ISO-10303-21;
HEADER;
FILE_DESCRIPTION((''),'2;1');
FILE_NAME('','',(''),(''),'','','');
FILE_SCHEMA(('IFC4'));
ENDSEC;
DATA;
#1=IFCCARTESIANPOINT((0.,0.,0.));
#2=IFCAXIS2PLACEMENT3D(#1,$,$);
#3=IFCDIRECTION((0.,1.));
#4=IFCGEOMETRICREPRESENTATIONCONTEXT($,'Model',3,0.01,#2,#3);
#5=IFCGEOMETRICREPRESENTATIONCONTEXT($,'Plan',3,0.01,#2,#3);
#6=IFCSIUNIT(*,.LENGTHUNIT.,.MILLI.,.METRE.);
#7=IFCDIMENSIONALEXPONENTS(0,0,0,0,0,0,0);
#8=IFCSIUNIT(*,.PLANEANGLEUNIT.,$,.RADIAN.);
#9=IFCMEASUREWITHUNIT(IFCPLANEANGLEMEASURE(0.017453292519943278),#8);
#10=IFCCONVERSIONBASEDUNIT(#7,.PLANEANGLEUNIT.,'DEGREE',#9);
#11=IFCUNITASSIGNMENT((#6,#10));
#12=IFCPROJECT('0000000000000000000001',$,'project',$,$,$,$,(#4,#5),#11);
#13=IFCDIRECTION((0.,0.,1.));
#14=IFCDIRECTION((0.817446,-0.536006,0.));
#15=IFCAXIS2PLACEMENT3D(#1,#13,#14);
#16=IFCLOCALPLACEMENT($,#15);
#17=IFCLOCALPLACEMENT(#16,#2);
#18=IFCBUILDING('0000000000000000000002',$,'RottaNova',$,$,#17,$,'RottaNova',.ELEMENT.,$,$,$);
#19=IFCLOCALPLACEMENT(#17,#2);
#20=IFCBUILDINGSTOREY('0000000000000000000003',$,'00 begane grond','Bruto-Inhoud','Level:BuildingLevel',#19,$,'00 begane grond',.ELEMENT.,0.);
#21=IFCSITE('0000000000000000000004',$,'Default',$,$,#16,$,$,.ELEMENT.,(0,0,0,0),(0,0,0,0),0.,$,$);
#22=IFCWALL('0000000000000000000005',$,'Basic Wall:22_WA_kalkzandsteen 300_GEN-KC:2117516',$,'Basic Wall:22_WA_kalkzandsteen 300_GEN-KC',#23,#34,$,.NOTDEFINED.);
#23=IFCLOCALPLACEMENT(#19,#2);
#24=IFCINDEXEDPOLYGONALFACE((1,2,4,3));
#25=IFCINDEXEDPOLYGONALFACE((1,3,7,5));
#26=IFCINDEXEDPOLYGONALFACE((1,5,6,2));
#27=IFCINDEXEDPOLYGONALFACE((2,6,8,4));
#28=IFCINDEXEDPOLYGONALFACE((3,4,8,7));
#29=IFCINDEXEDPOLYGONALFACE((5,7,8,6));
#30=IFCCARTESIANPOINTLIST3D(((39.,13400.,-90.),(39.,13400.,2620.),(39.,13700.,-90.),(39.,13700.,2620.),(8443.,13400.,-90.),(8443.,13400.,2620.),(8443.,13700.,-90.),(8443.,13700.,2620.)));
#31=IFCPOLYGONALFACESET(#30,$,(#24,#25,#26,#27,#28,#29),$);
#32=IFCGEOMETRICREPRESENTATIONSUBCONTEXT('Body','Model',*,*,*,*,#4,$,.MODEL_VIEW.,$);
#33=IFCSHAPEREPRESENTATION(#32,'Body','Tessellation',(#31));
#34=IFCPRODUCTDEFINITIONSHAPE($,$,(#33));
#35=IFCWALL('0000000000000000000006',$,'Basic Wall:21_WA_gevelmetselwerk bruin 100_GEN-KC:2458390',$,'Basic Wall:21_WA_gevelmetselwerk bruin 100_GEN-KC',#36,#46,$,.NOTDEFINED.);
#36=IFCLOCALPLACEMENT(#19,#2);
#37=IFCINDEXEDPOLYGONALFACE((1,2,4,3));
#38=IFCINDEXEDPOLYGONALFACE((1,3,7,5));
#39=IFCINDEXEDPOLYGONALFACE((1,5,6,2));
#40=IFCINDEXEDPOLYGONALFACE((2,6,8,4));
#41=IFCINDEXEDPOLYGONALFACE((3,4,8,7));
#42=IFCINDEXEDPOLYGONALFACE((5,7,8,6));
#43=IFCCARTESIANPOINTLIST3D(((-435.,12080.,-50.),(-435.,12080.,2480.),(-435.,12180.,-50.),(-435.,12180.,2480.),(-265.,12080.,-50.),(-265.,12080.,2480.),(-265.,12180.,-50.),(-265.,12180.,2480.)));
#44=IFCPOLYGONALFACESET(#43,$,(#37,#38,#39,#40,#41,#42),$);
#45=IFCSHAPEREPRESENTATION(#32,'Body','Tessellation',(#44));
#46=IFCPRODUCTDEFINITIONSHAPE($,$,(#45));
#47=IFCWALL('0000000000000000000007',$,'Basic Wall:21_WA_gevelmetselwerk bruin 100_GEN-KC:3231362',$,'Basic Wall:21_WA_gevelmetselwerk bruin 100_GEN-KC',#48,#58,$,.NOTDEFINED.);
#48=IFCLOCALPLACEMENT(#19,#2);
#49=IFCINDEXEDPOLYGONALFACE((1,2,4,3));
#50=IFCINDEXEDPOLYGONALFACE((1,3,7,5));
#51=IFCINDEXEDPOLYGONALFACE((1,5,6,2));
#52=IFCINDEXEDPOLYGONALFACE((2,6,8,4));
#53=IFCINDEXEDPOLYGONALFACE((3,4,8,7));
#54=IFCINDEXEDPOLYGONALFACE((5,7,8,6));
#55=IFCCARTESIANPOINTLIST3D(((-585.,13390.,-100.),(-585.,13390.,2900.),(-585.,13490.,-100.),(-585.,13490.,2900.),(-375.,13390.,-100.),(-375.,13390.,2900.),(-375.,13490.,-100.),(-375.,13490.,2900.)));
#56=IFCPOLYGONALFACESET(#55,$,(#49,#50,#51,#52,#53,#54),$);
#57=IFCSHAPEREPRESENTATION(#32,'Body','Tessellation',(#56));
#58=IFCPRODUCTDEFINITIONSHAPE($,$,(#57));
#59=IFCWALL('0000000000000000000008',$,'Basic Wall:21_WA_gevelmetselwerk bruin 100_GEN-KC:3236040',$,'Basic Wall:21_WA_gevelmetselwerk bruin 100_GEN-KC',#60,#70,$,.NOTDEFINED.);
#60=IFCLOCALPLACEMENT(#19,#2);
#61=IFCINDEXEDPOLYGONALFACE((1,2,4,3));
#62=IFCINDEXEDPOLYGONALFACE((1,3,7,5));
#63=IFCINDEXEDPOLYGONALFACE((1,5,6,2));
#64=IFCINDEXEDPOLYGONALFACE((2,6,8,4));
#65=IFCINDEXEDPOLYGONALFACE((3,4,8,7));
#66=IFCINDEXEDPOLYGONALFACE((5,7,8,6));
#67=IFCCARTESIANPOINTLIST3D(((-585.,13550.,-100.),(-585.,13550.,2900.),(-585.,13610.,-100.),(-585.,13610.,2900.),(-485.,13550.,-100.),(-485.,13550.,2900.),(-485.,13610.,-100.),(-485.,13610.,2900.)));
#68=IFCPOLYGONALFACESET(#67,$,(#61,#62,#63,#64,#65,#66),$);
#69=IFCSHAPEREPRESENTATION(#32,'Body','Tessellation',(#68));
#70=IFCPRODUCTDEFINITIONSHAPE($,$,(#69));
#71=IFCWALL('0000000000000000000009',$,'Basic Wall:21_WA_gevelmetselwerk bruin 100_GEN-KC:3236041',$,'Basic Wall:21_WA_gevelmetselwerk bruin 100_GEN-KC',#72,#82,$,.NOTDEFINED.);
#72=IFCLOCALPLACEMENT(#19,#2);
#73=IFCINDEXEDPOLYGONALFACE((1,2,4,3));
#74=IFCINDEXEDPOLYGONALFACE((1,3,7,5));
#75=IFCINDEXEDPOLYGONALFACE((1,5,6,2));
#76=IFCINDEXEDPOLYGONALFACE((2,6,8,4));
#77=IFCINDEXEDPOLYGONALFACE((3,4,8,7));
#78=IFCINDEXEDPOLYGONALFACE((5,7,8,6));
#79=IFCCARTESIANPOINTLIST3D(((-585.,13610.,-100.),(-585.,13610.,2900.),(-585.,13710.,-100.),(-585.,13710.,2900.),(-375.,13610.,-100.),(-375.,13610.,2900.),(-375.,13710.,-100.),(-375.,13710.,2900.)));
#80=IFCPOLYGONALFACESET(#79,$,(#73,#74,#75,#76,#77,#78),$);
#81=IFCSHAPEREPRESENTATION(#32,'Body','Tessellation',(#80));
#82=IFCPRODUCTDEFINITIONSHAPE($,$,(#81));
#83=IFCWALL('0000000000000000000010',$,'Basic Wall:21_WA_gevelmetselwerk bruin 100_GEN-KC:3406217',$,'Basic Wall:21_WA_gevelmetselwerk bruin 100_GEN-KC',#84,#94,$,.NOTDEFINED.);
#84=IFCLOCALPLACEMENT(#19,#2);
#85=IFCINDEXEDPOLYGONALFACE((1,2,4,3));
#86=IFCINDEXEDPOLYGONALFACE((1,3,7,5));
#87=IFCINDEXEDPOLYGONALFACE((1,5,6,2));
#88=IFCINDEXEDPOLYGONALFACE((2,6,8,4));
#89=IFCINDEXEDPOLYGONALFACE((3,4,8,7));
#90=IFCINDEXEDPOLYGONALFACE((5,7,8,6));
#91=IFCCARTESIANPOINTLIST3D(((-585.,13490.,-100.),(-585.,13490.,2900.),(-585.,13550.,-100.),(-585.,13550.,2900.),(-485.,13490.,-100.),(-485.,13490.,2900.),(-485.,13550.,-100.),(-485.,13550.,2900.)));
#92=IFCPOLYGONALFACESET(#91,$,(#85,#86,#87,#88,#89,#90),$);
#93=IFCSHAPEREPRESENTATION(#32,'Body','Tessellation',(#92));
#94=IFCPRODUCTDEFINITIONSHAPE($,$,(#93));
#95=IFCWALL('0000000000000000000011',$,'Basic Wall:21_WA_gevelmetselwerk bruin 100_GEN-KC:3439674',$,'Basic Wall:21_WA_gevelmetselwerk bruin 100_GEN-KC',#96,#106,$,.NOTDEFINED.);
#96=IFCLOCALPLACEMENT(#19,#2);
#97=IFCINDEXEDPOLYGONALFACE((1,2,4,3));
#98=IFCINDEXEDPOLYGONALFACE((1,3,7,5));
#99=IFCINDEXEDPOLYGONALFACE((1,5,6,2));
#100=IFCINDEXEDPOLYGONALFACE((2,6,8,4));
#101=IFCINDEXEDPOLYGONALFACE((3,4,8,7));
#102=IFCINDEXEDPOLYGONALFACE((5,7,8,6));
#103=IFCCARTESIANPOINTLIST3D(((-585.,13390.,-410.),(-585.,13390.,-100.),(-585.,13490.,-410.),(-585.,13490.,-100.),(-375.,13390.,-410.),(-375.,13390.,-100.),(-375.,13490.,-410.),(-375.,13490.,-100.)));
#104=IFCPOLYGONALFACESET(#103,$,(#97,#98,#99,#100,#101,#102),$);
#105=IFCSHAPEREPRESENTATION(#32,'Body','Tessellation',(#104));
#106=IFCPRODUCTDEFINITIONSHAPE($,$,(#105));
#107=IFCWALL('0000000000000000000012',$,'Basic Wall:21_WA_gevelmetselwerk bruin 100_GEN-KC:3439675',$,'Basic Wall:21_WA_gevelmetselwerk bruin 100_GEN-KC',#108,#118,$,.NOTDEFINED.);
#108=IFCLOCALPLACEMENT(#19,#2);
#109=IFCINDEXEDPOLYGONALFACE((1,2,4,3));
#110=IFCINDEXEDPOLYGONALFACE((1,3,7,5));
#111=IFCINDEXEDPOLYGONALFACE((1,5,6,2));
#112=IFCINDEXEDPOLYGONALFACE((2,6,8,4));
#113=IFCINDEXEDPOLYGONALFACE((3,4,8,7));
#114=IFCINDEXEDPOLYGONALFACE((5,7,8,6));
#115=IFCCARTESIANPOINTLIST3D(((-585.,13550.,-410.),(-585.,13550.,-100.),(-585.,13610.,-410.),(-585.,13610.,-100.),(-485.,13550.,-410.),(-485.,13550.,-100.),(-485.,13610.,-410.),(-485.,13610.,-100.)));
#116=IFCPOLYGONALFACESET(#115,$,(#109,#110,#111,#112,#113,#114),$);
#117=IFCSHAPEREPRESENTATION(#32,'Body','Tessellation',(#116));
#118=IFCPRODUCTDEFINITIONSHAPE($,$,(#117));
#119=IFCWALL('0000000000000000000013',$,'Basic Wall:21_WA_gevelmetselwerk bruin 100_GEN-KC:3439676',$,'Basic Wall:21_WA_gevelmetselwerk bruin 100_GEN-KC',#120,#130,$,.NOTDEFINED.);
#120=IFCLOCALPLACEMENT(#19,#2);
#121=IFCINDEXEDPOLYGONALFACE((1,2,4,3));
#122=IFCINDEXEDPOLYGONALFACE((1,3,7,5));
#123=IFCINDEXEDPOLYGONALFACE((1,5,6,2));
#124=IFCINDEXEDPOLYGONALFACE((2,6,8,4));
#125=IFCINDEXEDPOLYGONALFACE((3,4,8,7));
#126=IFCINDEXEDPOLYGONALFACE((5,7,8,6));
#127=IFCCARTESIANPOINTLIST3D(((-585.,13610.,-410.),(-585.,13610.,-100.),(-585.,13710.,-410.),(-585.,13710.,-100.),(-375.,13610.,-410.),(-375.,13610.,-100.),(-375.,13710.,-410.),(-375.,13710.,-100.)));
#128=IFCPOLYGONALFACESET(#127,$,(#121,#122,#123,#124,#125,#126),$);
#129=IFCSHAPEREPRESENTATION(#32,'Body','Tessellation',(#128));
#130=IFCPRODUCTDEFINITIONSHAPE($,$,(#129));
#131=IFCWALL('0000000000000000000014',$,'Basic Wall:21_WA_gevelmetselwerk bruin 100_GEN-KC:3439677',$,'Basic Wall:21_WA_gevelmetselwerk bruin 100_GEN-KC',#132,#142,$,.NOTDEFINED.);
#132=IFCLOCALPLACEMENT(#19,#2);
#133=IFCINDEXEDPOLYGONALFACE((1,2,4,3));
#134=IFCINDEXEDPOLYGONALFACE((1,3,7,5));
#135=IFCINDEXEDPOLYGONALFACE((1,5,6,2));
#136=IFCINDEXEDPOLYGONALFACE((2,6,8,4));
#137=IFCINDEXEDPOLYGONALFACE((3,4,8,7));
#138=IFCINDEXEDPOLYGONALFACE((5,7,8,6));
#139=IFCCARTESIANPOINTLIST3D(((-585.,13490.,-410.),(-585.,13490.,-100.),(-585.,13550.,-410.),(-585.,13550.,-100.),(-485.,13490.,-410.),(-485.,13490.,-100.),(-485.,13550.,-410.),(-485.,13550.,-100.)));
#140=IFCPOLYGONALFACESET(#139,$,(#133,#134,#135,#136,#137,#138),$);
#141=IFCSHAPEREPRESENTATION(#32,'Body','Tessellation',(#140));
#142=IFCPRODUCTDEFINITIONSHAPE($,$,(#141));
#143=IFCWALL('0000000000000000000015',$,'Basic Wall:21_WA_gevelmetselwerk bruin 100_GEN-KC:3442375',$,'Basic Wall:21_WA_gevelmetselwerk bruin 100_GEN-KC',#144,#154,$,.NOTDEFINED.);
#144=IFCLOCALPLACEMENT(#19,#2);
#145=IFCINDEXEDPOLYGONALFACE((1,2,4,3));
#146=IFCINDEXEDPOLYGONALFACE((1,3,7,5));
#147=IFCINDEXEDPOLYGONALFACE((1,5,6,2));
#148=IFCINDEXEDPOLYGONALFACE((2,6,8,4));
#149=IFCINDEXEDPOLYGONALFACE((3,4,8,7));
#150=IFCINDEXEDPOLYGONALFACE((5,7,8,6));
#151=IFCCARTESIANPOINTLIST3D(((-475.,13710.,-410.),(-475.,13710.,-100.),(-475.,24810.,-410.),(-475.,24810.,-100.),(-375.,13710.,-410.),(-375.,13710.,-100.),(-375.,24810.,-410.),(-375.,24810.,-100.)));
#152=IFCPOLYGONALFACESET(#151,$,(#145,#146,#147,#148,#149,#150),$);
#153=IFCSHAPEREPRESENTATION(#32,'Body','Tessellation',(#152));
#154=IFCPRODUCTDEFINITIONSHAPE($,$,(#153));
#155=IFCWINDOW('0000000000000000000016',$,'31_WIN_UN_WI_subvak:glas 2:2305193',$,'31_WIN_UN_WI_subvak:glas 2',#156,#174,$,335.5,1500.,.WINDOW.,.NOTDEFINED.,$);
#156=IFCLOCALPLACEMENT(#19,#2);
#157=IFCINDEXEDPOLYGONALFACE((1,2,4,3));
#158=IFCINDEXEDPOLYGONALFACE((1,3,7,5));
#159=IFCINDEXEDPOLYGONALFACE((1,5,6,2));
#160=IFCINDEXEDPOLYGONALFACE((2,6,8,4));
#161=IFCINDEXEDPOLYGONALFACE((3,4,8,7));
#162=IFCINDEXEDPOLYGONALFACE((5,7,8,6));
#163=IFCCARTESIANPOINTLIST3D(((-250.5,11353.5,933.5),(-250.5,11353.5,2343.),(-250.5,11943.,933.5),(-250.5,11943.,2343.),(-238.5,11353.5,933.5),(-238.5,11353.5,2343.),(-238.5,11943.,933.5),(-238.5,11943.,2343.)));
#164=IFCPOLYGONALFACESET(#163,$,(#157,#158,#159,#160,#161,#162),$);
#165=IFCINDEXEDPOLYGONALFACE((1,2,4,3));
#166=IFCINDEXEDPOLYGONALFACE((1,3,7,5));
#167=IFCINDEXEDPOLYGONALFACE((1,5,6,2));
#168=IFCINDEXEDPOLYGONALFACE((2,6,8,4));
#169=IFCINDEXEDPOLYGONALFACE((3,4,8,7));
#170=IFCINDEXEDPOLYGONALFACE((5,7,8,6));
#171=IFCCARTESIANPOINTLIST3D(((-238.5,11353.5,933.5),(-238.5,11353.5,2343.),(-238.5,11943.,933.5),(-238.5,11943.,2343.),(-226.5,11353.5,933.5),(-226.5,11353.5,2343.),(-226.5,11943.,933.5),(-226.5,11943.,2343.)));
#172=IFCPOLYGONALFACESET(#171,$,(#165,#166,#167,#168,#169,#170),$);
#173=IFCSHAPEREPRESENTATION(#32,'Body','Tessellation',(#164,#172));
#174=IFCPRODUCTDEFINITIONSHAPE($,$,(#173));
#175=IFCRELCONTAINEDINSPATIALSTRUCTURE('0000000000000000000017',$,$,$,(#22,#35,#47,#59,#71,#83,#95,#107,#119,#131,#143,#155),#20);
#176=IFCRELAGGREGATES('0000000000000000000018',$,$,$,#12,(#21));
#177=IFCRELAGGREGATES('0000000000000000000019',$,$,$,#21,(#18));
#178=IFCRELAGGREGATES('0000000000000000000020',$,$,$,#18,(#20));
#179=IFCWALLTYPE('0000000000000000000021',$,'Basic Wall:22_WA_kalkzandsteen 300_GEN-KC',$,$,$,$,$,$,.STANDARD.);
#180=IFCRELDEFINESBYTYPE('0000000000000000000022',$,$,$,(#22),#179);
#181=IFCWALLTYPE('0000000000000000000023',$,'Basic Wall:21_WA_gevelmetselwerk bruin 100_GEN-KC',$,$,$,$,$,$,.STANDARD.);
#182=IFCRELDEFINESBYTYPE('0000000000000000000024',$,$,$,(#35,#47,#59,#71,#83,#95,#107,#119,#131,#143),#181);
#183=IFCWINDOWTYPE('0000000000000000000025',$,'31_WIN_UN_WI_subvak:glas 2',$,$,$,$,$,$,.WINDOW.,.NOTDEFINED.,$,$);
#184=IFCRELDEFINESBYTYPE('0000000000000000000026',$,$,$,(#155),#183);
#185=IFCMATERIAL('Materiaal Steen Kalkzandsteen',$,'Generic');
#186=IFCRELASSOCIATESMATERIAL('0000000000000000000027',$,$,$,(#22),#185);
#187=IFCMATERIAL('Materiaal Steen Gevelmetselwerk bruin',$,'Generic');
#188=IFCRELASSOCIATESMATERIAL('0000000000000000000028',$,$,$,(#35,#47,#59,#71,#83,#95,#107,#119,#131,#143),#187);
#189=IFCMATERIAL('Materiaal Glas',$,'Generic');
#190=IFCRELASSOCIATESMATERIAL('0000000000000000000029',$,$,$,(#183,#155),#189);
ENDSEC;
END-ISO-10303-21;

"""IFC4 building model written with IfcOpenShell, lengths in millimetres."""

from ifc_helpers import new_model, entity, si_unit, converted_unit, direction, frame, origin, place, context, subcontext, project, spatial, indexed_curve, outline, extrude, source, transform, mapped, material, type_object, type_shapes, element, save


model = new_model("IFC4")

# Units and contexts
model_context = context("Model", 3, precision=0.01, world=origin(), true_north=direction((0.0, 1.0)))
plan_context = context("Plan", 3, precision=0.01, world=origin(), true_north=direction((0.0, 1.0)))
body_context = subcontext(model_context, "Body", "Model", "MODEL_VIEW")
ifc_project = project(units=[si_unit("LENGTHUNIT", "METRE", prefix="MILLI"), converted_unit("PLANEANGLEUNIT", "DEGREE", entity("IfcPlaneAngleMeasure", 0.017453292519943278), si_unit("PLANEANGLEUNIT", "RADIAN"), dimensions=[0, 0, 0, 0, 0, 0, 0])], contexts=[model_context, plan_context])

# Site, building, storey
site_placement = place(None, frame((0.0, 0.0, 0.0), z_axis=(0.0, 0.0, 1.0), x_axis=(0.817446, -0.536006, 0.0)))
site = spatial("IfcSite", under=ifc_project, at=site_placement, Name="Default", CompositionType="ELEMENT", RefLatitude=(0, 0, 0, 0), RefLongitude=(0, 0, 0, 0), RefElevation=0.0)
building_placement = place(site_placement, origin())
building = spatial("IfcBuilding", under=site, at=building_placement, Name="RottaNova", LongName="RottaNova", CompositionType="ELEMENT")
storey_placement = place(building_placement, origin())
storey = spatial("IfcBuildingStorey", under=building, at=storey_placement, Name="00 begane grond", Description="Bruto-Inhoud", ObjectType="Level:BuildingLevel", LongName="00 begane grond", CompositionType="ELEMENT", Elevation=0.0)

# Shared definitions
ifc_material_1 = material(Name="Materiaal Glas", Category="Generic")

# Walls
ifc_material_2 = material(Name="Materiaal Steen Kalkzandsteen", Category="Generic")
wall_type_1 = type_object("IfcWallType", Name="Basic Wall:22_WA_kalkzandsteen 300_GEN-KC", PredefinedType="STANDARD")
wall_1_placement = place(storey_placement, frame((39.0, 13550.0, -90.0)))
element("IfcWall", 1, at=wall_1_placement, inside=storey, type_object=wall_type_1, material=ifc_material_2, Name="Basic Wall:22_WA_kalkzandsteen 300_GEN-KC:2117516", ObjectType="Basic Wall:22_WA_kalkzandsteen 300_GEN-KC", PredefinedType="NOTDEFINED", context=body_context, shape_type="SweptSolid", body=[
    extrude(outline(indexed_curve([(8404.0, 150.0), (0.0, 150.0), (0.0, -150.0), (8404.0, -150.0), (8404.0, 150.0)], self_intersect=False)), origin(), (0.0, 0.0, 1.0), 2710.0),
])
ifc_material_3 = material(Name="Materiaal Steen Gevelmetselwerk bruin", Category="Generic")
wall_type_2 = type_object("IfcWallType", Name="Basic Wall:21_WA_gevelmetselwerk bruin 100_GEN-KC", PredefinedType="STANDARD")
wall_2_placement = place(storey_placement, frame((-435.0, 12130.0, -50.0)))
element("IfcWall", 2, at=wall_2_placement, inside=storey, type_object=wall_type_2, material=ifc_material_3, Name="Basic Wall:21_WA_gevelmetselwerk bruin 100_GEN-KC:2458390", ObjectType="Basic Wall:21_WA_gevelmetselwerk bruin 100_GEN-KC", PredefinedType="NOTDEFINED", context=body_context, shape_type="SweptSolid", body=[
    extrude(outline(indexed_curve([(170.0, 50.0), (0.0, 50.0), (0.0, -50.0), (170.0, -50.0), (170.0, 50.0)], self_intersect=False)), origin(), (0.0, 0.0, 1.0), 2530.0),
])
wall_3_placement = place(storey_placement, frame((-585.0, 13440.0, -100.0)))
element("IfcWall", 3, at=wall_3_placement, inside=storey, type_object=wall_type_2, material=ifc_material_3, Name="Basic Wall:21_WA_gevelmetselwerk bruin 100_GEN-KC:3231362", ObjectType="Basic Wall:21_WA_gevelmetselwerk bruin 100_GEN-KC", PredefinedType="NOTDEFINED", context=body_context, shape_type="SweptSolid", body=[
    extrude(outline(indexed_curve([(210.0, 50.0), (0.0, 50.0), (0.0, -50.0), (210.0, -50.0), (210.0, 50.0)], self_intersect=False)), origin(), (0.0, 0.0, 1.0), 3000.0),
])
wall_4_placement = place(storey_placement, frame((-535.0, 13550.0, -100.0), z_axis=(0.0, 0.0, 1.0), x_axis=(0.0, 1.0, 0.0)))
element("IfcWall", 4, at=wall_4_placement, inside=storey, type_object=wall_type_2, material=ifc_material_3, Name="Basic Wall:21_WA_gevelmetselwerk bruin 100_GEN-KC:3236040", ObjectType="Basic Wall:21_WA_gevelmetselwerk bruin 100_GEN-KC", PredefinedType="NOTDEFINED", context=body_context, shape_type="SweptSolid", body=[
    extrude(outline(indexed_curve([(60.0, 50.0), (0.0, 50.0), (0.0, -50.0), (60.0, -50.0), (60.0, 50.0)], self_intersect=False)), origin(), (0.0, 0.0, 1.0), 3000.0),
])
wall_5_placement = place(storey_placement, frame((-585.0, 13660.0, -100.0)))
element("IfcWall", 5, at=wall_5_placement, inside=storey, type_object=wall_type_2, material=ifc_material_3, Name="Basic Wall:21_WA_gevelmetselwerk bruin 100_GEN-KC:3236041", ObjectType="Basic Wall:21_WA_gevelmetselwerk bruin 100_GEN-KC", PredefinedType="NOTDEFINED", context=body_context, shape_type="SweptSolid", body=[
    extrude(outline(indexed_curve([(210.0, 50.0), (0.0, 50.0), (0.0, -50.0), (210.0, -50.0), (210.0, 50.0)], self_intersect=False)), origin(), (0.0, 0.0, 1.0), 3000.0),
])
wall_6_placement = place(storey_placement, frame((-535.0, 13490.0, -100.0), z_axis=(0.0, 0.0, 1.0), x_axis=(0.0, 1.0, 0.0)))
element("IfcWall", 6, at=wall_6_placement, inside=storey, type_object=wall_type_2, material=ifc_material_3, Name="Basic Wall:21_WA_gevelmetselwerk bruin 100_GEN-KC:3406217", ObjectType="Basic Wall:21_WA_gevelmetselwerk bruin 100_GEN-KC", PredefinedType="NOTDEFINED", context=body_context, shape_type="SweptSolid", body=[
    extrude(outline(indexed_curve([(60.0, 50.0), (0.0, 50.0), (0.0, -50.0), (60.0, -50.0), (60.0, 50.0)], self_intersect=False)), origin(), (0.0, 0.0, 1.0), 3000.0),
])
wall_7_placement = place(storey_placement, frame((-585.0, 13440.0, -410.0)))
element("IfcWall", 7, at=wall_7_placement, inside=storey, type_object=wall_type_2, material=ifc_material_3, Name="Basic Wall:21_WA_gevelmetselwerk bruin 100_GEN-KC:3439674", ObjectType="Basic Wall:21_WA_gevelmetselwerk bruin 100_GEN-KC", PredefinedType="NOTDEFINED", context=body_context, shape_type="SweptSolid", body=[
    extrude(outline(indexed_curve([(210.0, 50.0), (0.0, 50.0), (0.0, -50.0), (210.0, -50.0), (210.0, 50.0)], self_intersect=False)), origin(), (0.0, 0.0, 1.0), 310.0),
])
wall_8_placement = place(storey_placement, frame((-535.0, 13550.0, -410.0), z_axis=(0.0, 0.0, 1.0), x_axis=(0.0, 1.0, 0.0)))
element("IfcWall", 8, at=wall_8_placement, inside=storey, type_object=wall_type_2, material=ifc_material_3, Name="Basic Wall:21_WA_gevelmetselwerk bruin 100_GEN-KC:3439675", ObjectType="Basic Wall:21_WA_gevelmetselwerk bruin 100_GEN-KC", PredefinedType="NOTDEFINED", context=body_context, shape_type="SweptSolid", body=[
    extrude(outline(indexed_curve([(60.0, 50.0), (0.0, 50.0), (0.0, -50.0), (60.0, -50.0), (60.0, 50.0)], self_intersect=False)), origin(), (0.0, 0.0, 1.0), 310.0),
])
wall_9_placement = place(storey_placement, frame((-585.0, 13660.0, -410.0)))
element("IfcWall", 9, at=wall_9_placement, inside=storey, type_object=wall_type_2, material=ifc_material_3, Name="Basic Wall:21_WA_gevelmetselwerk bruin 100_GEN-KC:3439676", ObjectType="Basic Wall:21_WA_gevelmetselwerk bruin 100_GEN-KC", PredefinedType="NOTDEFINED", context=body_context, shape_type="SweptSolid", body=[
    extrude(outline(indexed_curve([(210.0, 50.0), (0.0, 50.0), (0.0, -50.0), (210.0, -50.0), (210.0, 50.0)], self_intersect=False)), origin(), (0.0, 0.0, 1.0), 310.0),
])
wall_10_placement = place(storey_placement, frame((-535.0, 13490.0, -410.0), z_axis=(0.0, 0.0, 1.0), x_axis=(0.0, 1.0, 0.0)))
element("IfcWall", 10, at=wall_10_placement, inside=storey, type_object=wall_type_2, material=ifc_material_3, Name="Basic Wall:21_WA_gevelmetselwerk bruin 100_GEN-KC:3439677", ObjectType="Basic Wall:21_WA_gevelmetselwerk bruin 100_GEN-KC", PredefinedType="NOTDEFINED", context=body_context, shape_type="SweptSolid", body=[
    extrude(outline(indexed_curve([(60.0, 50.0), (0.0, 50.0), (0.0, -50.0), (60.0, -50.0), (60.0, 50.0)], self_intersect=False)), origin(), (0.0, 0.0, 1.0), 310.0),
])
wall_11_placement = place(storey_placement, frame((-425.0, 13710.0, -410.0), z_axis=(0.0, 0.0, 1.0), x_axis=(0.0, 1.0, 0.0)))
element("IfcWall", 11, at=wall_11_placement, inside=storey, type_object=wall_type_2, material=ifc_material_3, Name="Basic Wall:21_WA_gevelmetselwerk bruin 100_GEN-KC:3442375", ObjectType="Basic Wall:21_WA_gevelmetselwerk bruin 100_GEN-KC", PredefinedType="NOTDEFINED", context=body_context, shape_type="SweptSolid", body=[
    extrude(outline(indexed_curve([(11100.0, 50.0), (0.0, 50.0), (0.0, -50.0), (11100.0, -50.0), (11100.0, 50.0)], self_intersect=False)), origin(), (0.0, 0.0, 1.0), 310.0),
])

# Window
window_type = type_object("IfcWindowType", Name="31_WIN_UN_WI_subvak:glas 2", PartitioningType="NOTDEFINED", PredefinedType="WINDOW", material=ifc_material_1)
shared_shape_1 = source(origin(), body_context, "Body", "SweptSolid", [
    extrude(outline(indexed_curve([(-6.0, -294.7), (6.0, -294.7), (6.0, 294.7), (-6.0, 294.7), (-6.0, -294.7)], self_intersect=False)), frame((0.0, 6.0, 0.0), z_axis=(0.0, 0.0, 1.0), x_axis=(0.0, -1.0, 0.0)), (0.0, 0.0, 1.0), 1409.5),
    extrude(outline(indexed_curve([(-6.0, -294.8), (6.0, -294.8), (6.0, 294.8), (-6.0, 294.8), (-6.0, -294.8)], self_intersect=False)), frame((0.0, -6.0, 0.0), z_axis=(0.0, 0.0, 1.0), x_axis=(0.0, -1.0, 0.0)), (0.0, 0.0, 1.0), 1409.5),
])
type_shapes(window_type, [shared_shape_1])
window_1_placement = place(storey_placement, frame((-238.5, 11648.2, 933.5), z_axis=(0.0, 0.0, 1.0), x_axis=(0.0, 1.0, 0.0)))
element("IfcWindow", 12, at=window_1_placement, inside=storey, type_object=window_type, material=ifc_material_1, Name="31_WIN_UN_WI_subvak:glas 2:2305193", ObjectType="31_WIN_UN_WI_subvak:glas 2", OverallHeight=335.5, OverallWidth=1500.0, PartitioningType="NOTDEFINED", PredefinedType="WINDOW", context=body_context, shape_type="MappedRepresentation", body=[
    mapped(shared_shape_1, transform((0.0, 0.0, 0.0), scale=1.0)),
])

save(model, "model.ifc")
